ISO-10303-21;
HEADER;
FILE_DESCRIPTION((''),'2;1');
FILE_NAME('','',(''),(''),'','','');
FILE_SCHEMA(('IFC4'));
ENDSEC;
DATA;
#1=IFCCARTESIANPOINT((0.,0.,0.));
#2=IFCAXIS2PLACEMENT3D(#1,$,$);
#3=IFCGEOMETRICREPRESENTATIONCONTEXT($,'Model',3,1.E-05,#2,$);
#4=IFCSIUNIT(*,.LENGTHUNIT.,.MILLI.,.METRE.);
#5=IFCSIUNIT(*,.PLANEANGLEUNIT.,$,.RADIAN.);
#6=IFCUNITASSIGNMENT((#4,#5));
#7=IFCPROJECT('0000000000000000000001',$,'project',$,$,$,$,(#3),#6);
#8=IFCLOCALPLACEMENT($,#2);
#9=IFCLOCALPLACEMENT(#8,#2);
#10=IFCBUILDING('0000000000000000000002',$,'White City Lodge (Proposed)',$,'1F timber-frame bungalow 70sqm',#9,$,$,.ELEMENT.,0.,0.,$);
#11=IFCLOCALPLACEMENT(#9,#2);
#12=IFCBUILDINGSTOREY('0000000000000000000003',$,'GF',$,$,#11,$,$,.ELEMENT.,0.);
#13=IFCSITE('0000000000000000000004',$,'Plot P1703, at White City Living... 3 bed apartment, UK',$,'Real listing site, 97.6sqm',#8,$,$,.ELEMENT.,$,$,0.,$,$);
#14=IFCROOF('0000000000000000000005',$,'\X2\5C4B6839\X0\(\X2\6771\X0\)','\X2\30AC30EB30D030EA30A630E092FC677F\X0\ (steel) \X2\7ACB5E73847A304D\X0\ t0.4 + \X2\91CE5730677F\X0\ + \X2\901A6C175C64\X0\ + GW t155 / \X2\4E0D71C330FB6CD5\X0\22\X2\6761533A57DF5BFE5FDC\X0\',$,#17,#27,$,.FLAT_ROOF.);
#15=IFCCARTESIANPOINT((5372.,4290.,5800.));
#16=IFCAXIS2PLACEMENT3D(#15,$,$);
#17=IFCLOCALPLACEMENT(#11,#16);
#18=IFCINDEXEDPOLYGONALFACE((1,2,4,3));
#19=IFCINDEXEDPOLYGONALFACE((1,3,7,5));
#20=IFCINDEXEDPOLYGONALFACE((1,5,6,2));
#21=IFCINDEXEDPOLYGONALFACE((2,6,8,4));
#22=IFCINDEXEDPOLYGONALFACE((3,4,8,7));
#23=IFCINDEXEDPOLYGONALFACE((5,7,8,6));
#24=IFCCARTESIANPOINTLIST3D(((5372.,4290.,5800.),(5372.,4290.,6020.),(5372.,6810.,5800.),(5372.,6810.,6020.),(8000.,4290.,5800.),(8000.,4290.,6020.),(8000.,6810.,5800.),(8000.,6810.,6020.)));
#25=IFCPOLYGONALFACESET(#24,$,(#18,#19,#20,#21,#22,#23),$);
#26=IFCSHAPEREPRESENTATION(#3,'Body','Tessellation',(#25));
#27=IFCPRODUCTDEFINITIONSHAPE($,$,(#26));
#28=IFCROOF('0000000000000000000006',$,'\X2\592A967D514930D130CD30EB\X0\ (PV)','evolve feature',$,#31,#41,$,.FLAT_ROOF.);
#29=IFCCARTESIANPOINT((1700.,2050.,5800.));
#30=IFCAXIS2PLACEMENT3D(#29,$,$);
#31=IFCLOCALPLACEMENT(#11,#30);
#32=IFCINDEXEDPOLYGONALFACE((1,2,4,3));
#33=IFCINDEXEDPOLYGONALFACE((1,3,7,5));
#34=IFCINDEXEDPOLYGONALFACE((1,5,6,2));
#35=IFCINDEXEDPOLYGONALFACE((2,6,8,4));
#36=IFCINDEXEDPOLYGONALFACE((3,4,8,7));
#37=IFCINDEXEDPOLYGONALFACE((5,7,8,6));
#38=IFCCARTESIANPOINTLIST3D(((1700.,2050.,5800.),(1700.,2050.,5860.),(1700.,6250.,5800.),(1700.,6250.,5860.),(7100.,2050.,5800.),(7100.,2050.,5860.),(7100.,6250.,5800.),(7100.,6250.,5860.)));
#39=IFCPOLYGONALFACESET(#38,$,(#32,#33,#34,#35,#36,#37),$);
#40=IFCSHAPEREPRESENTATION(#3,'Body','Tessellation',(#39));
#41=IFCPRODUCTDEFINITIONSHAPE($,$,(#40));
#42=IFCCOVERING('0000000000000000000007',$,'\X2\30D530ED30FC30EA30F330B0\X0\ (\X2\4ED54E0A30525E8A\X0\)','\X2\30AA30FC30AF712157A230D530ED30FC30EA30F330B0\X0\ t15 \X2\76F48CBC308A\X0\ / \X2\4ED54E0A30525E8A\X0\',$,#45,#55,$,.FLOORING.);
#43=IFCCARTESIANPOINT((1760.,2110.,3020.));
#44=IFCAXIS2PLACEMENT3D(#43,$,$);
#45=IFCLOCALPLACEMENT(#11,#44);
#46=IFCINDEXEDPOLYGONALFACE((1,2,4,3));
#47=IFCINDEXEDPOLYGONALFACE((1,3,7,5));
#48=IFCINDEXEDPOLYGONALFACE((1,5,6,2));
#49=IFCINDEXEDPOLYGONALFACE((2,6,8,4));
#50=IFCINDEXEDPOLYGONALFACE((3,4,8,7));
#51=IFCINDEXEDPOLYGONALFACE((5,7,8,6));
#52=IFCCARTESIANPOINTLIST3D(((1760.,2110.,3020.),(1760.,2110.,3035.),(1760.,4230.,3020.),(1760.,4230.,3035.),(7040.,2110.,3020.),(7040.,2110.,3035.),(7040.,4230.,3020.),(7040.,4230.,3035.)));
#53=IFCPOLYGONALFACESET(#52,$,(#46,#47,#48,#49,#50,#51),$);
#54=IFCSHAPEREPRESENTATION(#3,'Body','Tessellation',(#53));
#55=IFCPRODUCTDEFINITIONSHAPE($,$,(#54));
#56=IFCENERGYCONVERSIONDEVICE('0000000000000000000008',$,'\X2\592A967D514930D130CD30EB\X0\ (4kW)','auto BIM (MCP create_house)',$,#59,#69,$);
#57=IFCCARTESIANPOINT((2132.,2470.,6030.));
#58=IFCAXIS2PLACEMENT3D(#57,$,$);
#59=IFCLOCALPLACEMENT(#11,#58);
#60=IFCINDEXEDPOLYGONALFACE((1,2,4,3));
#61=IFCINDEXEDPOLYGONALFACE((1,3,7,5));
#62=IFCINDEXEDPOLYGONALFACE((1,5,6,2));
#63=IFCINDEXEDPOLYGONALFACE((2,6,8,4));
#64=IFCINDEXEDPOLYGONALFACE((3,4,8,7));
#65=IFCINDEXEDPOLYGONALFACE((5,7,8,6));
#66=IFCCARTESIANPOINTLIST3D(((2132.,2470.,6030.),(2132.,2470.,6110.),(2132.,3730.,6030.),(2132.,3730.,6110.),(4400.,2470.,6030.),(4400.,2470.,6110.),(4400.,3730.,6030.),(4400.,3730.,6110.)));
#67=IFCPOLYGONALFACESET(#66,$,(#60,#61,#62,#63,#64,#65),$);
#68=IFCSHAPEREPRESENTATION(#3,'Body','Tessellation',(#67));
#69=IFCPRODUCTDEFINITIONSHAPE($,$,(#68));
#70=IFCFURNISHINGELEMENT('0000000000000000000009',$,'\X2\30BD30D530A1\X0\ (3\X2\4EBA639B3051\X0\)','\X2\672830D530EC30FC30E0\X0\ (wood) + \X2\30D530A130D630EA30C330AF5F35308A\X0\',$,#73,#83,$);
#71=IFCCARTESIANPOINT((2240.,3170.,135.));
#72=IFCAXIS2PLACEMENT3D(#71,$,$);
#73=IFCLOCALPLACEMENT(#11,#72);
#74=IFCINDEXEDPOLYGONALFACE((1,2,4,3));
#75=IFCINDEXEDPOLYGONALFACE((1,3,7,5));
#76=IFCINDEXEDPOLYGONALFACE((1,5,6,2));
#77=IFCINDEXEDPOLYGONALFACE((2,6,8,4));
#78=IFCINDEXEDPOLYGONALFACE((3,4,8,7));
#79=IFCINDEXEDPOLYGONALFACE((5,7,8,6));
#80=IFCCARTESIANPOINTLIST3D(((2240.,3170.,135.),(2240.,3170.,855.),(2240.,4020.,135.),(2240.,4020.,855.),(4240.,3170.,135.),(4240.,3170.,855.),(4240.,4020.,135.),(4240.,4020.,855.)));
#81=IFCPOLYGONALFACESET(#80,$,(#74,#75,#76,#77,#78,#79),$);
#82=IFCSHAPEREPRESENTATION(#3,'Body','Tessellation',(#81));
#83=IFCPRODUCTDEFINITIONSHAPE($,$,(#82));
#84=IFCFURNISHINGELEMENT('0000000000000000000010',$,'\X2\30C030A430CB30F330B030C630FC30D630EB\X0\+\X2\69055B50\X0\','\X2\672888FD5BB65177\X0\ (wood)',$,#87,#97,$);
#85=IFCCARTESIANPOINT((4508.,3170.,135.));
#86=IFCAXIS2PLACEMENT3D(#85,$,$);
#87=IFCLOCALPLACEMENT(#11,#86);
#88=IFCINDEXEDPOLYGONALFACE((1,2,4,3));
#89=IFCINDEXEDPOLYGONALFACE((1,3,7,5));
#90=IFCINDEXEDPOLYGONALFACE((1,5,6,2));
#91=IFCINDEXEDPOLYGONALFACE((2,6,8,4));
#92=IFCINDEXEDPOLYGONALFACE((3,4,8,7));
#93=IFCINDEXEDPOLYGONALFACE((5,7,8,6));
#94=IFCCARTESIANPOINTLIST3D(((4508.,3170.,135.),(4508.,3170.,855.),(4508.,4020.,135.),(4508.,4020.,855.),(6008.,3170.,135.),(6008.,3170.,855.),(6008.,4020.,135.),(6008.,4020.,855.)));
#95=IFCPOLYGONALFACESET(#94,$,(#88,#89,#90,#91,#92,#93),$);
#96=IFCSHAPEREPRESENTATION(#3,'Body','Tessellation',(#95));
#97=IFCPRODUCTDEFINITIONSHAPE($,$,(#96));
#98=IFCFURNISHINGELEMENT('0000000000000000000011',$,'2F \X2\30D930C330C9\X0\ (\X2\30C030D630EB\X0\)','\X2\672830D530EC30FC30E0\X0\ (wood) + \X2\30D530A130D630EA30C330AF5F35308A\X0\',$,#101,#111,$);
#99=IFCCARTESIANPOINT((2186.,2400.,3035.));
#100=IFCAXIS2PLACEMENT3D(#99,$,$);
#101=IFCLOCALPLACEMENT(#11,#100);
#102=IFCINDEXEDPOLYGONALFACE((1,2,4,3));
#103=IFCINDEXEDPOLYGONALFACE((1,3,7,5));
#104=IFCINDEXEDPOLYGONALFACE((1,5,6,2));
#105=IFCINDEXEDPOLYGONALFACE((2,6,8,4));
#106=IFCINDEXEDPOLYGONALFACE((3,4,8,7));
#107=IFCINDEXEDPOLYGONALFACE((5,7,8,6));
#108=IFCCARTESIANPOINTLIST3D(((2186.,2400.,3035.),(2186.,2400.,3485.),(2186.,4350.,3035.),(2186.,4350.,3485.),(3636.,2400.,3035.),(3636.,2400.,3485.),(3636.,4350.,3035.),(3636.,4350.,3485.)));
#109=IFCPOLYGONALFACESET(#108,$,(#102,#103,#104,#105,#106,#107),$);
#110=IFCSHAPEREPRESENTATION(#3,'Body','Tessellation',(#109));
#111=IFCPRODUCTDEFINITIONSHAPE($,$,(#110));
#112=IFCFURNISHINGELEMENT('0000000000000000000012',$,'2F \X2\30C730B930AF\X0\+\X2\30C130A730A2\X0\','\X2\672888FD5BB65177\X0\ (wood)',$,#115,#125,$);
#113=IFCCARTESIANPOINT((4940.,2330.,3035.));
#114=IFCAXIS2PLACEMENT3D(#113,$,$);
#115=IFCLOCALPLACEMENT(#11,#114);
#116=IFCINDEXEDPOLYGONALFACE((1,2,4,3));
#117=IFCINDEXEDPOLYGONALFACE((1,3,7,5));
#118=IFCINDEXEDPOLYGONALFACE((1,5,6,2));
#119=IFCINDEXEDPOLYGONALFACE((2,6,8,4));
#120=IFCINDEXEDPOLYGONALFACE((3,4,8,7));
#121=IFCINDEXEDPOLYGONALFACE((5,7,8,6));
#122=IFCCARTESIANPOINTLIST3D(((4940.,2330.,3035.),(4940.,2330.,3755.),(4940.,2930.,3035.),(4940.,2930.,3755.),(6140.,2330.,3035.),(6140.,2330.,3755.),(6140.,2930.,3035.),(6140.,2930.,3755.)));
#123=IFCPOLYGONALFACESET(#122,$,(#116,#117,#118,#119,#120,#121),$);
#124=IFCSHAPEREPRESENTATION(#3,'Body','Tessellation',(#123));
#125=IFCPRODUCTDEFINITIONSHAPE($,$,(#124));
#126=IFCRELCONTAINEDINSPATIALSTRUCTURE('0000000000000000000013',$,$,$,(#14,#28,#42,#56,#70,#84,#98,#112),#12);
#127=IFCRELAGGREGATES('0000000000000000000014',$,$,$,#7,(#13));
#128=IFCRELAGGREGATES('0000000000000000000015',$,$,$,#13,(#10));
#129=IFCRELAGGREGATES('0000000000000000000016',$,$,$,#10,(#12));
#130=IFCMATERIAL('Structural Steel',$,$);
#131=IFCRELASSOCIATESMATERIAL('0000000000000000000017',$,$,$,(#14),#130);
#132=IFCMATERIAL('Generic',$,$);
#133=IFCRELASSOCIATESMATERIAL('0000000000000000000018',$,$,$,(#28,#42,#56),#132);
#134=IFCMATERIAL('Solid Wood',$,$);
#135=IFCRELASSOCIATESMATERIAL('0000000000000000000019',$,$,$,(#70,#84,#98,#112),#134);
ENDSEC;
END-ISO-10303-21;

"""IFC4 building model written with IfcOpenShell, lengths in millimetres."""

from ifc_helpers import new_model, si_unit, frame, frame_2d, origin, place, context, project, spatial, rectangle, extrude, material, element, save


model = new_model("IFC4")

# Units and contexts
model_context = context("Model", 3, precision=1e-05, world=origin())
ifc_project = project(units=[si_unit("LENGTHUNIT", "METRE", prefix="MILLI"), si_unit("PLANEANGLEUNIT", "RADIAN")], contexts=[model_context])

# Site, building, storey
site_placement = place(None, origin())
site = spatial("IfcSite", under=ifc_project, at=site_placement, Name="Plot P1703, at White City Living... 3 bed apartment, UK", ObjectType="Real listing site, 97.6sqm", CompositionType="ELEMENT", RefElevation=0.0)
building_placement = place(site_placement, origin())
building = spatial("IfcBuilding", under=site, at=building_placement, Name="White City Lodge (Proposed)", ObjectType="1F timber-frame bungalow 70sqm", CompositionType="ELEMENT", ElevationOfRefHeight=0.0, ElevationOfTerrain=0.0)
storey_placement = place(building_placement, origin())
storey = spatial("IfcBuildingStorey", under=building, at=storey_placement, Name="GF", CompositionType="ELEMENT", Elevation=0.0)

# Shared definitions
ifc_material_1 = material(Name="Solid Wood")

# Roofs
ifc_material_2 = material(Name="Structural Steel")
roof_1_placement = place(storey_placement, frame((5372.0, 4290.0, 5800.0)))
element("IfcRoof", 1, at=roof_1_placement, inside=storey, material=ifc_material_2, Name="屋根(東)", Description="ガルバリウム鋼板 (steel) 立平葺き t0.4 + 野地板 + 通気層 + GW t155 / 不燃・法22条区域対応", PredefinedType="FLAT_ROOF", context=model_context, shape_type="SweptSolid", body=[
    extrude(rectangle(XDim=2628.0, YDim=2520.0, at=frame_2d((1314.0, 1260.0))), frame((5372.0, 4290.0, 5800.0)), (0.0, 0.0, 1.0), 220.0),
])
ifc_material_3 = material(Name="Generic")
roof_2_placement = place(storey_placement, frame((1700.0, 2050.0, 5800.0)))
element("IfcRoof", 2, at=roof_2_placement, inside=storey, material=ifc_material_3, Name="太陽光パネル (PV)", Description="evolve feature", PredefinedType="FLAT_ROOF", context=model_context, shape_type="SweptSolid", body=[
    extrude(rectangle(XDim=5400.0, YDim=4200.0, at=frame_2d((2700.0, 2100.0))), frame((1700.0, 2050.0, 5800.0)), (0.0, 0.0, 1.0), 60.0),
])

# Covering
covering_placement = place(storey_placement, frame((1760.0, 2110.0, 3020.0)))
element("IfcCovering", 3, at=covering_placement, inside=storey, material=ifc_material_3, Name="フローリング (仕上げ床)", Description="オーク無垢フローリング t15 直貼り / 仕上げ床", PredefinedType="FLOORING", context=model_context, shape_type="SweptSolid", body=[
    extrude(rectangle(XDim=5280.0, YDim=2120.0, at=frame_2d((2640.0, 1060.0))), frame((1760.0, 2110.0, 3020.0)), (0.0, 0.0, 1.0), 15.0),
])

# Energy conversion device
energy_conversion_device_placement = place(storey_placement, frame((2132.0, 2470.0, 6030.0)))
element("IfcEnergyConversionDevice", 4, at=energy_conversion_device_placement, inside=storey, material=ifc_material_3, Name="太陽光パネル (4kW)", Description="auto BIM (MCP create_house)", context=model_context, shape_type="SweptSolid", body=[
    extrude(rectangle(XDim=2268.0, YDim=1260.0, at=frame_2d((1134.0, 630.0))), frame((2132.0, 2470.0, 6030.0)), (0.0, 0.0, 1.0), 80.0),
])

# Furnishing elements
furnishing_1_placement = place(storey_placement, frame((2240.0, 3170.0, 135.0)))
element("IfcFurnishingElement", 5, at=furnishing_1_placement, inside=storey, material=ifc_material_1, Name="ソファ (3人掛け)", Description="木フレーム (wood) + ファブリック張り", context=model_context, shape_type="SweptSolid", body=[
    extrude(rectangle(XDim=2000.0, YDim=850.0, at=frame_2d((1000.0, 425.0))), frame((2240.0, 3170.0, 135.0)), (0.0, 0.0, 1.0), 720.0),
])
furnishing_2_placement = place(storey_placement, frame((4508.0, 3170.0, 135.0)))
element("IfcFurnishingElement", 6, at=furnishing_2_placement, inside=storey, material=ifc_material_1, Name="ダイニングテーブル+椅子", Description="木製家具 (wood)", context=model_context, shape_type="SweptSolid", body=[
    extrude(rectangle(XDim=1500.0, YDim=850.0, at=frame_2d((750.0, 425.0))), frame((4508.0, 3170.0, 135.0)), (0.0, 0.0, 1.0), 720.0),
])
furnishing_3_placement = place(storey_placement, frame((2186.0, 2400.0, 3035.0)))
element("IfcFurnishingElement", 7, at=furnishing_3_placement, inside=storey, material=ifc_material_1, Name="2F ベッド (ダブル)", Description="木フレーム (wood) + ファブリック張り", context=model_context, shape_type="SweptSolid", body=[
    extrude(rectangle(XDim=1450.0, YDim=1950.0, at=frame_2d((725.0, 975.0))), frame((2186.0, 2400.0, 3035.0)), (0.0, 0.0, 1.0), 450.0),
])
furnishing_4_placement = place(storey_placement, frame((4940.0, 2330.0, 3035.0)))
element("IfcFurnishingElement", 8, at=furnishing_4_placement, inside=storey, material=ifc_material_1, Name="2F デスク+チェア", Description="木製家具 (wood)", context=model_context, shape_type="SweptSolid", body=[
    extrude(rectangle(XDim=1200.0, YDim=600.0, at=frame_2d((600.0, 300.0))), frame((4940.0, 2330.0, 3035.0)), (0.0, 0.0, 1.0), 720.0),
])

save(model, "model.ifc")
